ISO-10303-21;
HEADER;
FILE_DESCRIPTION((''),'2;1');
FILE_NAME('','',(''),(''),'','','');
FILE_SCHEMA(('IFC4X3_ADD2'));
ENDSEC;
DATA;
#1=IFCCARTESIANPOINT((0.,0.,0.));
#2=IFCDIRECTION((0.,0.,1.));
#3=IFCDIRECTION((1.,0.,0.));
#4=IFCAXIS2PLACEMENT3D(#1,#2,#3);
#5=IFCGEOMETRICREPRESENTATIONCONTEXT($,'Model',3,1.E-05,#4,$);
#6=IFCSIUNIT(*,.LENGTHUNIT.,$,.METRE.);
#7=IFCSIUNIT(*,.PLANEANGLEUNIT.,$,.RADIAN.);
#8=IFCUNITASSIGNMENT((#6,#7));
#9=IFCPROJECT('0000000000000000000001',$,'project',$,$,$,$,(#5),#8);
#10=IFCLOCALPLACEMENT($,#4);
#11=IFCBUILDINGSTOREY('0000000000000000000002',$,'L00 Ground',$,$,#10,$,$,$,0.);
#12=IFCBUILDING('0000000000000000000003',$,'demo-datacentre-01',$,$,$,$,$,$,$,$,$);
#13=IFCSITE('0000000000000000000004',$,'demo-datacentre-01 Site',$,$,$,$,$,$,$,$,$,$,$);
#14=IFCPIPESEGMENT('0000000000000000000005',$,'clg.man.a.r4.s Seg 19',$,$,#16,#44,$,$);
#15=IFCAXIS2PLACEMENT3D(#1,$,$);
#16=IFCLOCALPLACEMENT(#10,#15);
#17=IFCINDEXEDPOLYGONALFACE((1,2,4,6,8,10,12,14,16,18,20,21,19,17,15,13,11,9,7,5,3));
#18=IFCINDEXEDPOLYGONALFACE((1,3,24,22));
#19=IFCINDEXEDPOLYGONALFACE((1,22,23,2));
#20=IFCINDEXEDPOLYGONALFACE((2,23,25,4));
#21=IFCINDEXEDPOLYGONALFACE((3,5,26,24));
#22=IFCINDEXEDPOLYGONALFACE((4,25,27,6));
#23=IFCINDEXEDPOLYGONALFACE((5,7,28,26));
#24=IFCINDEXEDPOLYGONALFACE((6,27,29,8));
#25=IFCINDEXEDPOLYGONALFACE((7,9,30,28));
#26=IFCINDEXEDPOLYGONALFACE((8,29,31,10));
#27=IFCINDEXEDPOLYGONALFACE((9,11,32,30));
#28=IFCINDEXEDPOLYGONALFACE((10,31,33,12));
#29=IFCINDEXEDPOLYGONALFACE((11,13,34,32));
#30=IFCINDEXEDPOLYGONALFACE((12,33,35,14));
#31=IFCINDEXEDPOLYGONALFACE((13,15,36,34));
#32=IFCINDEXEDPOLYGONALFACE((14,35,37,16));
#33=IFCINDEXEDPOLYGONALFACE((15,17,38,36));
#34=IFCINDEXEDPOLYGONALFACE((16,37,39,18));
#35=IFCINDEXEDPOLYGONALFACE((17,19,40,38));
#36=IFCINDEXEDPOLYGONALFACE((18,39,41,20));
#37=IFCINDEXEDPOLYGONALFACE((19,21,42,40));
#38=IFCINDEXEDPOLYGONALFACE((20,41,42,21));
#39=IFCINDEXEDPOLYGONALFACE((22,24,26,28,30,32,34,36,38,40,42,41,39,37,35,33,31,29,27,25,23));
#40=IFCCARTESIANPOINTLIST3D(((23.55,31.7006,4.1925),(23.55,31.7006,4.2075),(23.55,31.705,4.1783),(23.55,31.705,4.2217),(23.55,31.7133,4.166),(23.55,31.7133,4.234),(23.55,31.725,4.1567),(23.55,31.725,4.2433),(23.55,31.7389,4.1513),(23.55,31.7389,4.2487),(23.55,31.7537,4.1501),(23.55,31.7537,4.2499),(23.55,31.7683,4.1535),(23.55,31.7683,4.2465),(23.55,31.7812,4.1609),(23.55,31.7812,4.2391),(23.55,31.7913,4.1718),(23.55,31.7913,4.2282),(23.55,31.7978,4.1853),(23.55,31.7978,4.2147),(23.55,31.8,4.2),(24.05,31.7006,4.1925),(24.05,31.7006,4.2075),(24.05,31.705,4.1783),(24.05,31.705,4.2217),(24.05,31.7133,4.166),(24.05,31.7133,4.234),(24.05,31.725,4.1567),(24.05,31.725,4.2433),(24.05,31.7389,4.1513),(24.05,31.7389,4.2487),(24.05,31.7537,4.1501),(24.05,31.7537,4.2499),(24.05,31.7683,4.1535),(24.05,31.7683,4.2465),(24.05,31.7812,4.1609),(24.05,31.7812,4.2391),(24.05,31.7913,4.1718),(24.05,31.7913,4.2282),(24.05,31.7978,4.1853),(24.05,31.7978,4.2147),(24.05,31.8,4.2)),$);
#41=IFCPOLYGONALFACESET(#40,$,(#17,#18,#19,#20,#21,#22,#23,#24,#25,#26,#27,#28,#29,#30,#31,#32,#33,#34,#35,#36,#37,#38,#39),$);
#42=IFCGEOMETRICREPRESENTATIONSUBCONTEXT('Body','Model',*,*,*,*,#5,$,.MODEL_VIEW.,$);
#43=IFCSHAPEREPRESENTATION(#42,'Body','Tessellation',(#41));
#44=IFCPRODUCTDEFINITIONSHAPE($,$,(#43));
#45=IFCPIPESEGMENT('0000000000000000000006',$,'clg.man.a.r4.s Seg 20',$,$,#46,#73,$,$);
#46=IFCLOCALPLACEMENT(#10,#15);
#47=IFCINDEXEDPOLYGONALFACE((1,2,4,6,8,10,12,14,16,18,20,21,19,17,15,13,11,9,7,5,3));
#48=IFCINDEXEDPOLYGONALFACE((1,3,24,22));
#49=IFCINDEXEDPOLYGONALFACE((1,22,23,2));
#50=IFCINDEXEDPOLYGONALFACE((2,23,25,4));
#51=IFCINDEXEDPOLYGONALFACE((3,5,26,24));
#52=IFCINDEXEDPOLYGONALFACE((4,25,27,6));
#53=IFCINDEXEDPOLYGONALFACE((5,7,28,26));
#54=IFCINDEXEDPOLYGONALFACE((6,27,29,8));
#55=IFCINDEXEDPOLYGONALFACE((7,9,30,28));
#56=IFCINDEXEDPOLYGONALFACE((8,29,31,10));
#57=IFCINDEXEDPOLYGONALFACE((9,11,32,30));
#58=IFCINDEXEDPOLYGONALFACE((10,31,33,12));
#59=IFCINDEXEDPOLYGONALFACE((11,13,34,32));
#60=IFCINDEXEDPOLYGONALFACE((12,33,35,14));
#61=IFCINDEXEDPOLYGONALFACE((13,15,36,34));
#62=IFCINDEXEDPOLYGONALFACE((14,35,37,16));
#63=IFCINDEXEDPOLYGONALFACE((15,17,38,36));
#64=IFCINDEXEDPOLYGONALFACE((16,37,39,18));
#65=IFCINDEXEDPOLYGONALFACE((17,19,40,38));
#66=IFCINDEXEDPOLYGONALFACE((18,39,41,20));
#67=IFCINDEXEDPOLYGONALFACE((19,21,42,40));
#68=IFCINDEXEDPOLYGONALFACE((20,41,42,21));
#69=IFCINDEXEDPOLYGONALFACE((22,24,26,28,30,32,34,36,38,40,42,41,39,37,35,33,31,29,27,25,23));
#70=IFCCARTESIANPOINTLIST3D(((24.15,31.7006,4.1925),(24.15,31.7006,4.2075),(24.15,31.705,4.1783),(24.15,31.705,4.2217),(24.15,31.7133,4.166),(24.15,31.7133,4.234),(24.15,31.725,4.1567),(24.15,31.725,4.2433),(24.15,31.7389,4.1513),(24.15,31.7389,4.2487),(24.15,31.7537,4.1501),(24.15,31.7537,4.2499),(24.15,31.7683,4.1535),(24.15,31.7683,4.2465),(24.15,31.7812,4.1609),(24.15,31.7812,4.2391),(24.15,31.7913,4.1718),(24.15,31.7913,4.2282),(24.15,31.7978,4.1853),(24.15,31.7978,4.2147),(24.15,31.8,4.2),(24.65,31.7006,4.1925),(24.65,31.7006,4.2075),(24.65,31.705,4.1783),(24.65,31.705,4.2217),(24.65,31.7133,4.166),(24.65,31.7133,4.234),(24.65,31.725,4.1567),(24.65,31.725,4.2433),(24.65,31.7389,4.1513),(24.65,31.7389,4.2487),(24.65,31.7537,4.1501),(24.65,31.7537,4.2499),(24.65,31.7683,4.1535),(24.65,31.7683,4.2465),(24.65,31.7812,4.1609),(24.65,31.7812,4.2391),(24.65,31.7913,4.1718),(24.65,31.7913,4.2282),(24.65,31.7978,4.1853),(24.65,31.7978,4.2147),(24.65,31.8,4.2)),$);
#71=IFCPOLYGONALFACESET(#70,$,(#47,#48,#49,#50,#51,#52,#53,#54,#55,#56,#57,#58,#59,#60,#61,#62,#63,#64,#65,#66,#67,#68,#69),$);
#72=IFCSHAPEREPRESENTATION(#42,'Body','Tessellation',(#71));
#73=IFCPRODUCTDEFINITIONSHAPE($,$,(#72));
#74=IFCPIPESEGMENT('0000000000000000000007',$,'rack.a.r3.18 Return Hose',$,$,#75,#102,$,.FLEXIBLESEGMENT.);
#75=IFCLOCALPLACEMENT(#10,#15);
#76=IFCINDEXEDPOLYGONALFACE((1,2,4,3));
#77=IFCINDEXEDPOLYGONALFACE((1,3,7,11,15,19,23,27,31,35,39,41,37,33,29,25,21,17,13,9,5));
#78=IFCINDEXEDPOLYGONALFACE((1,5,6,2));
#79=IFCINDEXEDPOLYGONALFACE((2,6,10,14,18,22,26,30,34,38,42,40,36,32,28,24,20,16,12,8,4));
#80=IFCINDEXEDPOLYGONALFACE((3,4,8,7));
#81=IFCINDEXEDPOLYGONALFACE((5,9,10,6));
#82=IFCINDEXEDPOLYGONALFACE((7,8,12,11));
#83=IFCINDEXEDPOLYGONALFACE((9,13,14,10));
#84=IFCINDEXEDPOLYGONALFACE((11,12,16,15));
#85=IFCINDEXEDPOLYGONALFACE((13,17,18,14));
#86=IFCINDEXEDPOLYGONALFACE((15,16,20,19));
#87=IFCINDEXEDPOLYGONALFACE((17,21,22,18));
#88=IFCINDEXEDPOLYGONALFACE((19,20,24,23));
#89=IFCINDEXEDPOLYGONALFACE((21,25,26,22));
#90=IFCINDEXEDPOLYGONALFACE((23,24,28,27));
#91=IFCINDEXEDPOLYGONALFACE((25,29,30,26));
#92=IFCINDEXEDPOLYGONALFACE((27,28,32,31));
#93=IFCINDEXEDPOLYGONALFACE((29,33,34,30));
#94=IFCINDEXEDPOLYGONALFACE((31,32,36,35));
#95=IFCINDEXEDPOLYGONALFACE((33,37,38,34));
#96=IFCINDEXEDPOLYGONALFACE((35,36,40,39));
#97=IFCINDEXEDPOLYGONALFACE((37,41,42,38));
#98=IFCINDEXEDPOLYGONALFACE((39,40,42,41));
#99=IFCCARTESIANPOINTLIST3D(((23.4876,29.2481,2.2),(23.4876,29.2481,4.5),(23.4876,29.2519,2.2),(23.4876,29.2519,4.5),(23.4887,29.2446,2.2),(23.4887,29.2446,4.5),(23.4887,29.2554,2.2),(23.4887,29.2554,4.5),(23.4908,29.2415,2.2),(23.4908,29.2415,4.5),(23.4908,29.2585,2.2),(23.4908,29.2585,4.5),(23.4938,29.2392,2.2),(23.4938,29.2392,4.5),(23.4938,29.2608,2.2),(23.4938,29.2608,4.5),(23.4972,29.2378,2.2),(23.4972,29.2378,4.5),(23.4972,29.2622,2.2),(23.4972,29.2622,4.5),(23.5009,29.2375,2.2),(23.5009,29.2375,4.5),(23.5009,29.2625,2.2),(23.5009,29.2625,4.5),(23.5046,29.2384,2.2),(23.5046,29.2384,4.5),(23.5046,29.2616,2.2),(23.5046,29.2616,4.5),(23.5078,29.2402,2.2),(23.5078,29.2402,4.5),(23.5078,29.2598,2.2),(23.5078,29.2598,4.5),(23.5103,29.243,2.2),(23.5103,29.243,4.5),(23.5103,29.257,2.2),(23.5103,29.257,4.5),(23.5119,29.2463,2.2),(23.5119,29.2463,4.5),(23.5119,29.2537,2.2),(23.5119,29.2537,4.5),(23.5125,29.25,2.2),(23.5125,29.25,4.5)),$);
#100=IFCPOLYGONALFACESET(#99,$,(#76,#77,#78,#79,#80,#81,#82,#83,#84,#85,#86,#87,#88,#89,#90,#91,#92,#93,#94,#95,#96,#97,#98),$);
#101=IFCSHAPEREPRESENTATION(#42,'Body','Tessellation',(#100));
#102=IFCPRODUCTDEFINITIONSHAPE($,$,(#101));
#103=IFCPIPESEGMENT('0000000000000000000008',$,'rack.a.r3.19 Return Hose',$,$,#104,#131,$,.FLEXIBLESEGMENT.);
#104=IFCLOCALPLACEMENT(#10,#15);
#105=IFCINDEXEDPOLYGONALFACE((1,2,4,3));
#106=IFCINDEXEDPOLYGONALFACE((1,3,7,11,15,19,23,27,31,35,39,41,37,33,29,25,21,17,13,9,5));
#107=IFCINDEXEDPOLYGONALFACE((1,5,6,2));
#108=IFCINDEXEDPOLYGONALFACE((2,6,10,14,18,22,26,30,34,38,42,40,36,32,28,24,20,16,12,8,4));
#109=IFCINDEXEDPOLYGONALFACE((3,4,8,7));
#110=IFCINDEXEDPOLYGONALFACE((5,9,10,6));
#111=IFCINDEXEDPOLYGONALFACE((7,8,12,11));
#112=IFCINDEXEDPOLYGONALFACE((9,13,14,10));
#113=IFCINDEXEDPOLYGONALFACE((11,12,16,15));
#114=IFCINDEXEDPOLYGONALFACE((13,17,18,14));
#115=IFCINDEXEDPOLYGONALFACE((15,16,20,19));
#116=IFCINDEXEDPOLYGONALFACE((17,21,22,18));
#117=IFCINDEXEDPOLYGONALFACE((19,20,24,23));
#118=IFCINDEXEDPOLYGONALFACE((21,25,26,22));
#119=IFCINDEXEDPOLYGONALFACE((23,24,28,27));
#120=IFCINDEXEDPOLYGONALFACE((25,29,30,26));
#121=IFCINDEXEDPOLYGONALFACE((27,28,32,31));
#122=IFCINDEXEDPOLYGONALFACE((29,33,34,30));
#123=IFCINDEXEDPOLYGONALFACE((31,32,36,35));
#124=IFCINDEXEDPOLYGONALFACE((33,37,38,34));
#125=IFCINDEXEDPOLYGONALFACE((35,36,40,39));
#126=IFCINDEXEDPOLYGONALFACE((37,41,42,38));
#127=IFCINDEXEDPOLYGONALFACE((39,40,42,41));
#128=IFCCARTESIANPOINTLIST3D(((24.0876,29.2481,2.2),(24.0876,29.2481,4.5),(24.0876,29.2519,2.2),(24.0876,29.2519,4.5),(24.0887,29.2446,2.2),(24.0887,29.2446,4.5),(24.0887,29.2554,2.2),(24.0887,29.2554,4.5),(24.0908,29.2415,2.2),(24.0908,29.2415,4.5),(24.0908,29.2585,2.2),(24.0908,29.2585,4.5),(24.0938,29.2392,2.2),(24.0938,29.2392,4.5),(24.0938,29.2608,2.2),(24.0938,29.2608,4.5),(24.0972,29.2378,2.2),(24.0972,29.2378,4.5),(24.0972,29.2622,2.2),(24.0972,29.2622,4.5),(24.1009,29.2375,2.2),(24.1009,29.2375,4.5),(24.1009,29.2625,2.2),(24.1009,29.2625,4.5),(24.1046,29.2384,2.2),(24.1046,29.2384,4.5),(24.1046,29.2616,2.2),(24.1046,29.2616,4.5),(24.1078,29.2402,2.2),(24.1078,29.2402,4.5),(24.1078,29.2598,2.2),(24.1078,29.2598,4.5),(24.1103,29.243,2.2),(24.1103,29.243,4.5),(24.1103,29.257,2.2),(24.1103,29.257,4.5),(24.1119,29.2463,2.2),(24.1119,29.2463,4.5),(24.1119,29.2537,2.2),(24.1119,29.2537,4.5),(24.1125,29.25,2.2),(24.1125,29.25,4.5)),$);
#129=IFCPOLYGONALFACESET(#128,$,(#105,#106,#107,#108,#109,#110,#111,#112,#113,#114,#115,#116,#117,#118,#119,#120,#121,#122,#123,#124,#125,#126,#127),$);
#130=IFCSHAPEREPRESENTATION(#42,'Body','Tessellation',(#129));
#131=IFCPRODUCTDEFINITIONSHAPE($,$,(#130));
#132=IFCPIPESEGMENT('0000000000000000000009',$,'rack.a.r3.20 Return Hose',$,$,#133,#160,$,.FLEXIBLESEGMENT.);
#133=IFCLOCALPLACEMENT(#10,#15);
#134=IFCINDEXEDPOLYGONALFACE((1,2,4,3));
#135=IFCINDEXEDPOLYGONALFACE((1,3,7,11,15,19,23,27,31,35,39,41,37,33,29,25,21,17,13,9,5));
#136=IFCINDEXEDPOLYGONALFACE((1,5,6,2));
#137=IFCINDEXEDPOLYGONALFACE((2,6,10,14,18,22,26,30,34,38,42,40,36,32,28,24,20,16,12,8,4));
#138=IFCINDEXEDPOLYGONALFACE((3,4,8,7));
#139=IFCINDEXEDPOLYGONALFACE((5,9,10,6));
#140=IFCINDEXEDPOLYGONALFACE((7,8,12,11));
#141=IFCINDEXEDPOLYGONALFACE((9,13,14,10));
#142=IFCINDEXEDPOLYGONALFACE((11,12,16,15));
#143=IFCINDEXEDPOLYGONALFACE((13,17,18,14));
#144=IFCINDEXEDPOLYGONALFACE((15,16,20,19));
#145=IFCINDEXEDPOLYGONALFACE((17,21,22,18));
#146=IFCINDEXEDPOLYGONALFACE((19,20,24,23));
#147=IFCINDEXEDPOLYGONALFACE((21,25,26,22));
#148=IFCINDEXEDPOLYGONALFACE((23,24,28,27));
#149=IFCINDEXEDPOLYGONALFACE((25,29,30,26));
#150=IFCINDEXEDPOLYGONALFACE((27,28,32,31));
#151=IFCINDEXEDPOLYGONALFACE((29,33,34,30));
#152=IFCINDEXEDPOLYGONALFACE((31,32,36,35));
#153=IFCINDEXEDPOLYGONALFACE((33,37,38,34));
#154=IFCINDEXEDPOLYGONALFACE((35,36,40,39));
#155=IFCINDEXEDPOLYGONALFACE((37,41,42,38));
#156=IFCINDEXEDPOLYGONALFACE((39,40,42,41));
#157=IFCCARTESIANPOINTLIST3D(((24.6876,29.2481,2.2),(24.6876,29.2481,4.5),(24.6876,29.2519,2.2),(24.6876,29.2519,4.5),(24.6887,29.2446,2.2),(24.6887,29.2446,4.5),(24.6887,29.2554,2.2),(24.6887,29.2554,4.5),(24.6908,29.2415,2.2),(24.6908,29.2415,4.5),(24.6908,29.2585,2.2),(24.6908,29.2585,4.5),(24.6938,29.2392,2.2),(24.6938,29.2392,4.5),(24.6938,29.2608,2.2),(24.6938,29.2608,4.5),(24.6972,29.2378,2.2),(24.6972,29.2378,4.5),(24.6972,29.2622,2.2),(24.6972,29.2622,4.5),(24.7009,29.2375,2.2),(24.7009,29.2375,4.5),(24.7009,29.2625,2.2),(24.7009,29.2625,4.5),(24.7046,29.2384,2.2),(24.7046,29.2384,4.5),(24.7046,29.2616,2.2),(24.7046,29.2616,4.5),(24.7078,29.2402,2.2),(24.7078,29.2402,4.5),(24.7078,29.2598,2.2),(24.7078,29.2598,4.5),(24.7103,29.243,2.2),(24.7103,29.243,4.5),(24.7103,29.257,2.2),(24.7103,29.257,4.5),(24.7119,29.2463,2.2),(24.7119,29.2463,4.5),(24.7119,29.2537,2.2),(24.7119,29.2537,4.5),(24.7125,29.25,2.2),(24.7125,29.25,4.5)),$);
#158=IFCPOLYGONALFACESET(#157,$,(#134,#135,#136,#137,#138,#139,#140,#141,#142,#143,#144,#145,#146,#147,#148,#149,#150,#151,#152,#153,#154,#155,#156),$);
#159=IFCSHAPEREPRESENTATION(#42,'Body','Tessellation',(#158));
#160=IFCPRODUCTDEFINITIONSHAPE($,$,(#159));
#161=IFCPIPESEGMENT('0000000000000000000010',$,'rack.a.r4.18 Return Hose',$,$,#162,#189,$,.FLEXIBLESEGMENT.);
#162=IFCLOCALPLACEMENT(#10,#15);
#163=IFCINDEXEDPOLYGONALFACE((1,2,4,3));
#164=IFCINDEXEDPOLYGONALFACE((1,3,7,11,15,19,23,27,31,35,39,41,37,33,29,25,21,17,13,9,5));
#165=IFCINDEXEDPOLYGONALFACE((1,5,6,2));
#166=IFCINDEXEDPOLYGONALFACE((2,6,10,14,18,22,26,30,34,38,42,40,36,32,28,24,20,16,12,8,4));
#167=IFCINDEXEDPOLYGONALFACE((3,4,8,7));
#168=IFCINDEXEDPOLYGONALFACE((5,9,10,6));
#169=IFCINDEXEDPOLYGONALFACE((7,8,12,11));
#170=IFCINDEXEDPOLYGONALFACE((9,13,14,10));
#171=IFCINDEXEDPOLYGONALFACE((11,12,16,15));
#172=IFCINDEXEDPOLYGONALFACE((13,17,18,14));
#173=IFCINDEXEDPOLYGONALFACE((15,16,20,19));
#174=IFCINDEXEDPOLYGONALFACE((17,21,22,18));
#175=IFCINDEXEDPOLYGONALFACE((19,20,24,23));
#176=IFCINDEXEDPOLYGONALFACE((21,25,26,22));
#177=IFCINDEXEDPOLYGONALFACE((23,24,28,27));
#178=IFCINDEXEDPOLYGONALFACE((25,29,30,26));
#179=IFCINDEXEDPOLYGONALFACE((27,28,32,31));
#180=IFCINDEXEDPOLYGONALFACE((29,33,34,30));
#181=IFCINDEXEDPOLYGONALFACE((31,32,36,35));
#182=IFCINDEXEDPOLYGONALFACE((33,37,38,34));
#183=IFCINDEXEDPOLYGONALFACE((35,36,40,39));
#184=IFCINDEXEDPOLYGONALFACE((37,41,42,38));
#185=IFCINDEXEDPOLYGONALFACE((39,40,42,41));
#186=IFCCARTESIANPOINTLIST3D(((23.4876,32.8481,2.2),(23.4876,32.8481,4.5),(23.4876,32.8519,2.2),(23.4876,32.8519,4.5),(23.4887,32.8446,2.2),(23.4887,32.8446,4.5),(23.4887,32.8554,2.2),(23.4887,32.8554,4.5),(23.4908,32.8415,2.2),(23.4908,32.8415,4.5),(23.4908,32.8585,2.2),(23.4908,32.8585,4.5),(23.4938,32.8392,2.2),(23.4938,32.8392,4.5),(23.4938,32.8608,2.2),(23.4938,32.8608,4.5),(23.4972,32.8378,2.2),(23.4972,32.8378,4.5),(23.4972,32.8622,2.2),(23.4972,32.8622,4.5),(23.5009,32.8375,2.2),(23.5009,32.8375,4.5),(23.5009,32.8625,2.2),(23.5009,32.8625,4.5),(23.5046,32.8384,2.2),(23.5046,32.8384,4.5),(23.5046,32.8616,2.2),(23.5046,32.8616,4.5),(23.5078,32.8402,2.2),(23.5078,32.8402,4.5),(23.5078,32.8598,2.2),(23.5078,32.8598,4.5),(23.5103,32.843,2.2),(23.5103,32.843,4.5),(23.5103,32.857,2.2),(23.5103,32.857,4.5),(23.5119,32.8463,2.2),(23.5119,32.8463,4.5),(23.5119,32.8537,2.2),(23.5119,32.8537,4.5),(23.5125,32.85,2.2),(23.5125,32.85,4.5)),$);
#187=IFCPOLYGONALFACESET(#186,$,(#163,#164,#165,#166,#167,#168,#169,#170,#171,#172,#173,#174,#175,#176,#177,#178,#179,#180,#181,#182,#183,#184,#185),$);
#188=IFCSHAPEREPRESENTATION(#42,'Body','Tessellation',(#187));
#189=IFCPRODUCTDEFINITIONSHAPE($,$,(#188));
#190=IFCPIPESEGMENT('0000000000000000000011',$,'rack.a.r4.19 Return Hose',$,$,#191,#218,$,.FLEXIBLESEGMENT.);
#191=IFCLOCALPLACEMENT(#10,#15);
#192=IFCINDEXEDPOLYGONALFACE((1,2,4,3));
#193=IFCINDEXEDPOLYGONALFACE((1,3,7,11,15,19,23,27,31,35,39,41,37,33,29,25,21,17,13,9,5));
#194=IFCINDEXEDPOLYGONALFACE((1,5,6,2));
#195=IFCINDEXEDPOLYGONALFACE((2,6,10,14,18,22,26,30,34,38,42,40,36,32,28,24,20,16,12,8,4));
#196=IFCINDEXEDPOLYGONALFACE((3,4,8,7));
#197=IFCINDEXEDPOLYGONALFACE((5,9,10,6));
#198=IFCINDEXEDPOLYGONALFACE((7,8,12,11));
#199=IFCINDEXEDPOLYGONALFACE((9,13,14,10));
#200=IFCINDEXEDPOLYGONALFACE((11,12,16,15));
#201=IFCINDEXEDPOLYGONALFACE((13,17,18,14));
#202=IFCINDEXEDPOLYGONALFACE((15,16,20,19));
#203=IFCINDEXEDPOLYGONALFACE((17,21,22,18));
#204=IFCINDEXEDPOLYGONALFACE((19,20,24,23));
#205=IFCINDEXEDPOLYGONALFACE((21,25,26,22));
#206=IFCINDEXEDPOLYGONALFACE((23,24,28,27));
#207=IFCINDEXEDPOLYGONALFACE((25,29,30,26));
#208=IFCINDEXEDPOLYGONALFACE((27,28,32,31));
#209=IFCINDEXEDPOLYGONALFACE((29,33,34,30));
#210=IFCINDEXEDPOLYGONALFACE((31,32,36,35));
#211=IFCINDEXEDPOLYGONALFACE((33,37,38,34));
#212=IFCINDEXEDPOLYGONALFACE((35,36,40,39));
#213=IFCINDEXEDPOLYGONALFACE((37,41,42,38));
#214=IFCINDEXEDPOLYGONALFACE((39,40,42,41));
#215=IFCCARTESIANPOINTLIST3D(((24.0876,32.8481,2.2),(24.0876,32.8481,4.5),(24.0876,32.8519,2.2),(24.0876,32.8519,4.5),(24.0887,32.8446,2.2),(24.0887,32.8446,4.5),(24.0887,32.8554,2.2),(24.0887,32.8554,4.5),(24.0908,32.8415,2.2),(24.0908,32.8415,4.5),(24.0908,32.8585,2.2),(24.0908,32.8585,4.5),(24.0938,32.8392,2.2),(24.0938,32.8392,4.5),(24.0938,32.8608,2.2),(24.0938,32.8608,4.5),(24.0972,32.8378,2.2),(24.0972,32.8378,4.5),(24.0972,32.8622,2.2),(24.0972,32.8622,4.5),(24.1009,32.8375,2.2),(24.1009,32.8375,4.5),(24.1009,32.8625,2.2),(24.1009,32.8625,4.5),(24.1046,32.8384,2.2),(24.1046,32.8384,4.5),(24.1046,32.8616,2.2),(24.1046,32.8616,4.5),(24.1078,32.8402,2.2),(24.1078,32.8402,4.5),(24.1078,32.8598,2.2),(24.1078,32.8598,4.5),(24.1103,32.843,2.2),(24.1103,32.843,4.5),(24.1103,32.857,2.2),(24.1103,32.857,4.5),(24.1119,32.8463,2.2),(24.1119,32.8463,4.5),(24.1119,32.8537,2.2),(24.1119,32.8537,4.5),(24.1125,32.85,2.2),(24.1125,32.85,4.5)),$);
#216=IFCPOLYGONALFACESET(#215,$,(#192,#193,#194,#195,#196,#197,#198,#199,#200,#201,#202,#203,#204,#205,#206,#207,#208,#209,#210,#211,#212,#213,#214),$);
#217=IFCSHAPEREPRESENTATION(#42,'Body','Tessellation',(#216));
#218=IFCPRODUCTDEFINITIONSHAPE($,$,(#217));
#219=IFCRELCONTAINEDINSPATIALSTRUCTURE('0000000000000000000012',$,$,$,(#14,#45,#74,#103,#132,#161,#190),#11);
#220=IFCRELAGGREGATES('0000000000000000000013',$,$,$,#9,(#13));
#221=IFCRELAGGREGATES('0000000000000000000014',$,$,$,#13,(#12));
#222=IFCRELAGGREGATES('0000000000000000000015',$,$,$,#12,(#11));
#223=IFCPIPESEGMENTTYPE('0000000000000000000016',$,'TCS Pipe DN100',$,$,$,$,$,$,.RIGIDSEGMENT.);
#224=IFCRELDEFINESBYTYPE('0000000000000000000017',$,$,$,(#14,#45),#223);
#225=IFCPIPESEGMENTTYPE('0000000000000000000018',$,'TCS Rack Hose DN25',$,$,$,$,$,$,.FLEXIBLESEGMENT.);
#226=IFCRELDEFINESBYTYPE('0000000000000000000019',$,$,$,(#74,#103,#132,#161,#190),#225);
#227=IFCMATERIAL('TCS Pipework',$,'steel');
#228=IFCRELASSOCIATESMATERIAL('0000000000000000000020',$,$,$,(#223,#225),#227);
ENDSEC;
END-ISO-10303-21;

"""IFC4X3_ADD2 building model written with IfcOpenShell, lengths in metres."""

from ifc_helpers import new_model, si_unit, frame, origin_with_axes, place, context, subcontext, project, spatial, circle, extrude, material, type_object, element, save


model = new_model("IFC4X3_ADD2")

# Units and contexts
model_context = context("Model", 3, precision=1e-05, world=origin_with_axes())
body_context = subcontext(model_context, "Body", "Model", "MODEL_VIEW")
ifc_project = project(units=[si_unit("LENGTHUNIT", "METRE"), si_unit("PLANEANGLEUNIT", "RADIAN")], contexts=[model_context])

# Site, building, storey
site = spatial("IfcSite", under=ifc_project, Name="demo-datacentre-01 Site")
building = spatial("IfcBuilding", under=site, Name="demo-datacentre-01")
storey_placement = place(None, origin_with_axes())
storey = spatial("IfcBuildingStorey", under=building, at=storey_placement, Name="L00 Ground", Elevation=0.0)

# Shared definitions
ifc_material = material(Name="TCS Pipework", Category="steel")

# Pipe segments
pipe_segment_type_1 = type_object("IfcPipeSegmentType", Name="TCS Pipe DN100", PredefinedType="RIGIDSEGMENT", material=ifc_material)
for number, where, z_axis, x_axis, name in (
    (1, (23.55, 31.75, 4.2), (1.0, 0.0, 0.0), (0.0, 1.0, 0.0), "clg.man.a.r4.s Seg 19"),
    (2, (24.15, 31.75, 4.2), (1.0, 0.0, 0.0), (0.0, 1.0, 0.0), "clg.man.a.r4.s Seg 20"),
):
    element("IfcPipeSegment", number, at=place(storey_placement, frame(where, z_axis=z_axis, x_axis=x_axis)), inside=storey, type_object=pipe_segment_type_1, Name=name, context=body_context, shape_type="SweptSolid", body=[
        extrude(circle(Radius=0.05), origin_with_axes(), (0.0, 0.0, 1.0), 0.5),
    ])
pipe_segment_type_2 = type_object("IfcPipeSegmentType", Name="TCS Rack Hose DN25", PredefinedType="FLEXIBLESEGMENT", material=ifc_material)
for number, where, z_axis, x_axis, name in (
    (3, (23.5, 29.25, 4.5), (0.0, 0.0, -1.0), (1.0, 0.0, 0.0), "rack.a.r3.18 Return Hose"),
    (4, (24.1, 29.25, 4.5), (0.0, 0.0, -1.0), (1.0, 0.0, 0.0), "rack.a.r3.19 Return Hose"),
    (5, (24.7, 29.25, 4.5), (0.0, 0.0, -1.0), (1.0, 0.0, 0.0), "rack.a.r3.20 Return Hose"),
    (6, (23.5, 32.85, 4.5), (0.0, 0.0, -1.0), (1.0, 0.0, 0.0), "rack.a.r4.18 Return Hose"),
    (7, (24.1, 32.85, 4.5), (0.0, 0.0, -1.0), (1.0, 0.0, 0.0), "rack.a.r4.19 Return Hose"),
):
    element("IfcPipeSegment", number, at=place(storey_placement, frame(where, z_axis=z_axis, x_axis=x_axis)), inside=storey, type_object=pipe_segment_type_2, Name=name, PredefinedType="FLEXIBLESEGMENT", context=body_context, shape_type="SweptSolid", body=[
        extrude(circle(Radius=0.0125), origin_with_axes(), (0.0, 0.0, 1.0), 2.3),
    ])

save(model, "model.ifc")
